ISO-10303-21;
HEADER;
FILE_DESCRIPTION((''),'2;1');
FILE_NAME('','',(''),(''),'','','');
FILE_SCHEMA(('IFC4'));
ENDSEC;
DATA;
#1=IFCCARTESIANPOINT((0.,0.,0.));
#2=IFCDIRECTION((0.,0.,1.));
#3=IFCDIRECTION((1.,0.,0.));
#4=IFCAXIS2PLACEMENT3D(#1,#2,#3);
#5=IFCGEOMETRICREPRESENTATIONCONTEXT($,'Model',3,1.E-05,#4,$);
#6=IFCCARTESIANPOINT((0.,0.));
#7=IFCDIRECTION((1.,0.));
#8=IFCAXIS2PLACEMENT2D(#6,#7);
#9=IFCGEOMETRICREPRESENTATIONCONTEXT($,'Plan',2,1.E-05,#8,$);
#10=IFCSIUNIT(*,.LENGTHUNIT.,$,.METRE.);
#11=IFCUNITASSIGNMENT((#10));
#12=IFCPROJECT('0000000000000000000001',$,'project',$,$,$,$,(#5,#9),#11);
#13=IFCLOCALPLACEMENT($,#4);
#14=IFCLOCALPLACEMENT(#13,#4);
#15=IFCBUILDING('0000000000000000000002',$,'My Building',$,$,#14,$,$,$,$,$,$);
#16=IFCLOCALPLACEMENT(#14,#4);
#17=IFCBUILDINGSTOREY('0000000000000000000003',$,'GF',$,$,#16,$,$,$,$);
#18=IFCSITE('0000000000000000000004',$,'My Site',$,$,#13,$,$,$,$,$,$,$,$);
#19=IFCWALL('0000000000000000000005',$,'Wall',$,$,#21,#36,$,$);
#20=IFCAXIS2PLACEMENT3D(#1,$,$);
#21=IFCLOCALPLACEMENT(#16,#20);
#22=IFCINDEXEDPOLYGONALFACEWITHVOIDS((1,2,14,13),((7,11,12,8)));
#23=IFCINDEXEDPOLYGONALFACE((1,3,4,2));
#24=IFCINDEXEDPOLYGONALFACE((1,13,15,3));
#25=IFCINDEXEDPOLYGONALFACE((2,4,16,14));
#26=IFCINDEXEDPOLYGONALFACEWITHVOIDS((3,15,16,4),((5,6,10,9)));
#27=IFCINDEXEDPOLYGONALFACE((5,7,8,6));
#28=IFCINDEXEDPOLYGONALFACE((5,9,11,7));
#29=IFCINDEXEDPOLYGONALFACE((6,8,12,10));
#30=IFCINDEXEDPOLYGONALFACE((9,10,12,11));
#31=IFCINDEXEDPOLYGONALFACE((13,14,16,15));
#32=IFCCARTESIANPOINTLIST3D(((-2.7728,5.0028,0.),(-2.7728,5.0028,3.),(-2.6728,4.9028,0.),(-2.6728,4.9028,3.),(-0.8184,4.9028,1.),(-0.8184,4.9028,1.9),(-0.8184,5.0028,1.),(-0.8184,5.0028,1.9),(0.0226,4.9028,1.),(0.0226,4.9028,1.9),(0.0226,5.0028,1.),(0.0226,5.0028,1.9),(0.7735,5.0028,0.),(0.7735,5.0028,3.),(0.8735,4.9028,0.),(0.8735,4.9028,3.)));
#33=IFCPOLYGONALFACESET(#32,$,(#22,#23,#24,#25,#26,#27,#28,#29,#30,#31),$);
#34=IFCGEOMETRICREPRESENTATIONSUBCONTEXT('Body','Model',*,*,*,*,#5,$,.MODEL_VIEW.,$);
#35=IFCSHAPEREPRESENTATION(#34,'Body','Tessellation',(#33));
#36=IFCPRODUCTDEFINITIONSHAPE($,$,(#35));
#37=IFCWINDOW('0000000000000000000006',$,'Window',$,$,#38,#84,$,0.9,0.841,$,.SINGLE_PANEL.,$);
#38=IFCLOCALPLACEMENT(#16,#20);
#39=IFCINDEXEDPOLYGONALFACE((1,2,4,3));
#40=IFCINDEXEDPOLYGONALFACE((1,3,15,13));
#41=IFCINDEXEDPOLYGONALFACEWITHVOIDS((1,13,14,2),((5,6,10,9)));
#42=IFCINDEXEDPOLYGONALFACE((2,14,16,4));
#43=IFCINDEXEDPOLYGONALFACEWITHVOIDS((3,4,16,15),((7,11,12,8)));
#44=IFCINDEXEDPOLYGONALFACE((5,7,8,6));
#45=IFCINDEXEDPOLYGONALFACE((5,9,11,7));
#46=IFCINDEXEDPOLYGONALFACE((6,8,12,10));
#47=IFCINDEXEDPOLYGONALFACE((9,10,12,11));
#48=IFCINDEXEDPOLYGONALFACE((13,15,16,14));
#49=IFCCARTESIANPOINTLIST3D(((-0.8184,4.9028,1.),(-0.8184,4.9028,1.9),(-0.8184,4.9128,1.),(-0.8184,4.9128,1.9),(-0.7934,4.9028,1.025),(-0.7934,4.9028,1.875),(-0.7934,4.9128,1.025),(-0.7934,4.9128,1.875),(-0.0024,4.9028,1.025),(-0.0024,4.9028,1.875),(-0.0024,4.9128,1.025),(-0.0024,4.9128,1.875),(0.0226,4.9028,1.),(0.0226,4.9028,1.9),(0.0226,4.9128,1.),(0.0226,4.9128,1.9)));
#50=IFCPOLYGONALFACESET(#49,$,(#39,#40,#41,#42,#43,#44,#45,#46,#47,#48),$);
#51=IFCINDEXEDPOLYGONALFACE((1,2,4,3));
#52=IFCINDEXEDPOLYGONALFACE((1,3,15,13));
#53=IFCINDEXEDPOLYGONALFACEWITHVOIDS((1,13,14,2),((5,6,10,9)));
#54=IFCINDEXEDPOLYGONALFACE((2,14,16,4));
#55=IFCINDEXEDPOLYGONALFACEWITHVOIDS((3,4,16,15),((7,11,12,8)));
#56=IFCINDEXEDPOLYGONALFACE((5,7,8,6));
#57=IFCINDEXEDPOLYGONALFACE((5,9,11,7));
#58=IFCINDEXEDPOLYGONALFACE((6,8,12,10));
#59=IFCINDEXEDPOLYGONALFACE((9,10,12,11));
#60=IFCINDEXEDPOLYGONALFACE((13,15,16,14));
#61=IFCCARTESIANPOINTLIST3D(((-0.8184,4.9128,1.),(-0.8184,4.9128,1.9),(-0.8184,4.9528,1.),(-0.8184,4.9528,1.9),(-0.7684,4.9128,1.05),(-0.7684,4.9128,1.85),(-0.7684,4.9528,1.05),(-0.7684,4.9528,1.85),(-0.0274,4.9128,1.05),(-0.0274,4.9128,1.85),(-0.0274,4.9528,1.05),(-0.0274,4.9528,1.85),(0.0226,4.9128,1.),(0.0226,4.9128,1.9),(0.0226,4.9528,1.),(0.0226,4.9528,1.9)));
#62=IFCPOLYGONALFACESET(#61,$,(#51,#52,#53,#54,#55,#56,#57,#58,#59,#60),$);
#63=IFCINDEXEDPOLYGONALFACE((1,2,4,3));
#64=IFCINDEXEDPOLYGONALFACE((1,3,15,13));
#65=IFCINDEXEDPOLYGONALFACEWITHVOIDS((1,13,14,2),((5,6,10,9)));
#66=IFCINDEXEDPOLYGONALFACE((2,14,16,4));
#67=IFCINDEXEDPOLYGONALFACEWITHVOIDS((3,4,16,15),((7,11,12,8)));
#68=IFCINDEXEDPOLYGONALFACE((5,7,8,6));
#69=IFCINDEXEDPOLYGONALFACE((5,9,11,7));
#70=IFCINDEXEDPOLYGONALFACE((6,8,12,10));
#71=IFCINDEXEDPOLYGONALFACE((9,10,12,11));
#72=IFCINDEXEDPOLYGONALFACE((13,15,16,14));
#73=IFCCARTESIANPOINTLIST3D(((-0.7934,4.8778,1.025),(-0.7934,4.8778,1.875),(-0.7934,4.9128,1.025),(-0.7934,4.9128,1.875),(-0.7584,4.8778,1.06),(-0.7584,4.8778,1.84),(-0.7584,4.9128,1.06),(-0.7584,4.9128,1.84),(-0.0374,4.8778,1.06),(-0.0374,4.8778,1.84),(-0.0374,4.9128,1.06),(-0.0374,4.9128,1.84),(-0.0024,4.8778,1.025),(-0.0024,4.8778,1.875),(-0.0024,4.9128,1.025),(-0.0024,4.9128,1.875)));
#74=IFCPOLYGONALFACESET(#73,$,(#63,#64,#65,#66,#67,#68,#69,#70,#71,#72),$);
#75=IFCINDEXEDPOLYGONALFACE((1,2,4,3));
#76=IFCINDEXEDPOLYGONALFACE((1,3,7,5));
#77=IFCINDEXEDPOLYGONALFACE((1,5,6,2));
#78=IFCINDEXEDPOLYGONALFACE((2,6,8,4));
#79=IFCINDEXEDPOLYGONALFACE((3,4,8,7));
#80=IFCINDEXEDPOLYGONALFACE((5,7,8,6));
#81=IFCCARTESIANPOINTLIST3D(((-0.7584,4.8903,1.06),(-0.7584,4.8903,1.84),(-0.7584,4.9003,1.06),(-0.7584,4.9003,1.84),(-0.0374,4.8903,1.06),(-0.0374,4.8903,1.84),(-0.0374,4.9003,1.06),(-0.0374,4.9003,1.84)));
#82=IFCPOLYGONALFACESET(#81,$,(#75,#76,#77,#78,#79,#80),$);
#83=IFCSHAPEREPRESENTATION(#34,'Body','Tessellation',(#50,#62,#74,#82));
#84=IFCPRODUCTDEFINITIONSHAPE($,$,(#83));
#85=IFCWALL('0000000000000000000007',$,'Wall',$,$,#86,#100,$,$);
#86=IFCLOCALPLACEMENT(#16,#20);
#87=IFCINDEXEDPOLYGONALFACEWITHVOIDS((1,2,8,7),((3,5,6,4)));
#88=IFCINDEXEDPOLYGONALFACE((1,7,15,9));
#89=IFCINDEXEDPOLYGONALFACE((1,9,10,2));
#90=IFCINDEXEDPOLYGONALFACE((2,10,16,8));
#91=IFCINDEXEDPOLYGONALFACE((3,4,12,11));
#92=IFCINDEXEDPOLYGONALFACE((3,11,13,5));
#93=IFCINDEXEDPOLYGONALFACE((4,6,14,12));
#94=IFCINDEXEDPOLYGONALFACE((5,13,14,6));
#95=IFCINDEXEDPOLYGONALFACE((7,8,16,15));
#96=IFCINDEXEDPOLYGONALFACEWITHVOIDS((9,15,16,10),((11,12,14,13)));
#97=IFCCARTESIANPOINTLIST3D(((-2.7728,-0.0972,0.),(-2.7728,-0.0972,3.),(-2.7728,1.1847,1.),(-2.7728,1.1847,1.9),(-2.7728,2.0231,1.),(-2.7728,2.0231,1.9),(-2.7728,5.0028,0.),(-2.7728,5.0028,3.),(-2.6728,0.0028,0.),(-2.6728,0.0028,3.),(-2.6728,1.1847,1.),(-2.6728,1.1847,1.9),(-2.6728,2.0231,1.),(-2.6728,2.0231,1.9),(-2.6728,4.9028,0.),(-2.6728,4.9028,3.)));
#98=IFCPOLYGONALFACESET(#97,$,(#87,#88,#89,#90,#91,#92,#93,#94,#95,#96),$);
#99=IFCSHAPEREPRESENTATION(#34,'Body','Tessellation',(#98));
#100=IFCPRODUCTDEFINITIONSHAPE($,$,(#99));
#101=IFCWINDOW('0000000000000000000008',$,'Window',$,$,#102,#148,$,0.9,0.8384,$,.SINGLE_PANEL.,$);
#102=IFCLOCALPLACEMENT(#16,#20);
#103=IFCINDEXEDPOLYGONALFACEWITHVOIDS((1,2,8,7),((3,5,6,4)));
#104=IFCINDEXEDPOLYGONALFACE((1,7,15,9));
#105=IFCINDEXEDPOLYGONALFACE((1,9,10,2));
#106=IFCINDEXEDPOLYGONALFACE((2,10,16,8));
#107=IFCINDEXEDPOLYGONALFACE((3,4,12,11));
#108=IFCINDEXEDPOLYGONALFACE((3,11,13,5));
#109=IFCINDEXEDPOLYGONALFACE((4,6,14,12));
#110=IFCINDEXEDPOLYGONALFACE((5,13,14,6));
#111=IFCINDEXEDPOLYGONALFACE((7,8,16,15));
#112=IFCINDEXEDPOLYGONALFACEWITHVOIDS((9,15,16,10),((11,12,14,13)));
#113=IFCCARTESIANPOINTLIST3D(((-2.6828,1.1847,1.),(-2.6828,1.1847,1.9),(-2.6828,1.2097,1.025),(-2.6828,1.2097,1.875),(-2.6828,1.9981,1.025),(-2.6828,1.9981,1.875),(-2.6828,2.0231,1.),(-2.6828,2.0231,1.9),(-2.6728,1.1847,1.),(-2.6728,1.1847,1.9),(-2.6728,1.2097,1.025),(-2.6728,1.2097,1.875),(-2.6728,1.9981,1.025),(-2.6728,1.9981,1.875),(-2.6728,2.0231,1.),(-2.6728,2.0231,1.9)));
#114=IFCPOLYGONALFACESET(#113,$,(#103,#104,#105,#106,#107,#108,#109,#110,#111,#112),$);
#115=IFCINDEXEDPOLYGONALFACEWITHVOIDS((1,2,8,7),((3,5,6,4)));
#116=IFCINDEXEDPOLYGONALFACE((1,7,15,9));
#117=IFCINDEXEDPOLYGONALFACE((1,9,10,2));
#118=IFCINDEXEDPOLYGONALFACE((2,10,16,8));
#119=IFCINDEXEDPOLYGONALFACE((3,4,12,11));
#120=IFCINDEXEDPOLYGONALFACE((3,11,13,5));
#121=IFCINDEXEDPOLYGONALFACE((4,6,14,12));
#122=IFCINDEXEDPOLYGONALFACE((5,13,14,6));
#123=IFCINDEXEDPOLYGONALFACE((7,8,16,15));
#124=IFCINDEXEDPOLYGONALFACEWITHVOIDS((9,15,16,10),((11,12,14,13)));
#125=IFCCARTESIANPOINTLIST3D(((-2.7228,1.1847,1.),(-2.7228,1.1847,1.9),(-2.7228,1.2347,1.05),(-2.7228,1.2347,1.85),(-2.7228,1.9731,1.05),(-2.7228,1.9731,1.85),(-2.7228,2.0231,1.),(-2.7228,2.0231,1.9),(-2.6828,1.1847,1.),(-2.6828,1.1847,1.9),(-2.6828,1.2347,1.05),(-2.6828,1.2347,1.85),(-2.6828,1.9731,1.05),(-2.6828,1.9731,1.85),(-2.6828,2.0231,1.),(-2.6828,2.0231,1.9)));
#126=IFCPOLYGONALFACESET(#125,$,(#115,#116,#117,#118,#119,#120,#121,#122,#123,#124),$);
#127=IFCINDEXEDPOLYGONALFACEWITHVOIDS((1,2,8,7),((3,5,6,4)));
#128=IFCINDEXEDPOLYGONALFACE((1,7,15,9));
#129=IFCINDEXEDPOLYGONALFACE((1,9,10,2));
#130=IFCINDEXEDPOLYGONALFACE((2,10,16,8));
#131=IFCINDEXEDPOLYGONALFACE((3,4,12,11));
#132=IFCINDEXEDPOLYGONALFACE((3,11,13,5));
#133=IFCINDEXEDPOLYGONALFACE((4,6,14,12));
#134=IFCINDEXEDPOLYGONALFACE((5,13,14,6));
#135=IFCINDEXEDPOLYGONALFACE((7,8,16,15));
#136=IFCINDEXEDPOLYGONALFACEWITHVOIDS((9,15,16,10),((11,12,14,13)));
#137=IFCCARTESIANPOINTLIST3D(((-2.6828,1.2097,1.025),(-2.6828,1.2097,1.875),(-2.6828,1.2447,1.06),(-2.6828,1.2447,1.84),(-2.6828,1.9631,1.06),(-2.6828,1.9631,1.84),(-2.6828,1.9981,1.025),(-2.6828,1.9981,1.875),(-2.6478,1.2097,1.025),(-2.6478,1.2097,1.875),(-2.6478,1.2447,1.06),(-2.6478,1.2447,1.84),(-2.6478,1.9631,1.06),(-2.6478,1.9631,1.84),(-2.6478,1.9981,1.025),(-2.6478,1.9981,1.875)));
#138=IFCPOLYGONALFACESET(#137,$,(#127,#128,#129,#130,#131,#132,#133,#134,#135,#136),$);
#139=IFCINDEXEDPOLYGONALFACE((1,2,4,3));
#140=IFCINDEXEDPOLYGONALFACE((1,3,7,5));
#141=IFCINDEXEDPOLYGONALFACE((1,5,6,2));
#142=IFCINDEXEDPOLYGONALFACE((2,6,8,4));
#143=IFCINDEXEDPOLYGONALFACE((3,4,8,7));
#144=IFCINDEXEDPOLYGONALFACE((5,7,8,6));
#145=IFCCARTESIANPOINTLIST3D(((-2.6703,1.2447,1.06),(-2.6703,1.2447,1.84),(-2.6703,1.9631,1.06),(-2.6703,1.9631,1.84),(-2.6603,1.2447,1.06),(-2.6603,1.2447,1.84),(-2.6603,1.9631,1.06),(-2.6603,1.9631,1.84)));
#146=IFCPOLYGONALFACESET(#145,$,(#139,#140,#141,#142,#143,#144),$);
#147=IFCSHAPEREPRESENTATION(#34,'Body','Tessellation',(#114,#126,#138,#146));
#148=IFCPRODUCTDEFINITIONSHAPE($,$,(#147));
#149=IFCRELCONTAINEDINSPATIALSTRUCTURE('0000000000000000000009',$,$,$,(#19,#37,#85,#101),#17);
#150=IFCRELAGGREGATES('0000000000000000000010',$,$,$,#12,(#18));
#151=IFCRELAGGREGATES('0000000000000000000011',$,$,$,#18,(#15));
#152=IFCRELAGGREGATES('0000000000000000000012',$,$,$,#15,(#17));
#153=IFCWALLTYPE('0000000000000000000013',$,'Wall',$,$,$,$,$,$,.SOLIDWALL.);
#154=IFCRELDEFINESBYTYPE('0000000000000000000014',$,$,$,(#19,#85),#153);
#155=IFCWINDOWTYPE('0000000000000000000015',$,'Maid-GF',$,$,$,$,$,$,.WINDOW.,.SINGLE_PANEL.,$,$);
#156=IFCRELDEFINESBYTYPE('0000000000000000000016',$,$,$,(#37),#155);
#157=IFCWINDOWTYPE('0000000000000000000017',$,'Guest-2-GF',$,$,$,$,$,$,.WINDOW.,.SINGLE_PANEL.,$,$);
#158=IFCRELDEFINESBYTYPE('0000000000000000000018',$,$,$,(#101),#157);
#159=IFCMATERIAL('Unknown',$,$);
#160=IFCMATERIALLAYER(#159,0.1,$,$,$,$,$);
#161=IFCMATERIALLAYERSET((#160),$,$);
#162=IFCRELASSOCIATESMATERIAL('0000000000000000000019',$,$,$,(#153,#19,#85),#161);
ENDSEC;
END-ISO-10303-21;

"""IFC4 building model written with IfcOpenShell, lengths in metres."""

from ifc_helpers import new_model, entity, si_unit, frame, origin_with_axes, origin_2d_with_axis, place, context, subcontext, project, spatial, line, indexed_curve, outline, extrude, shape, source, transform, mapped, material, layer, layer_set, layer_usage, type_object, type_shapes, element, fill, save


model = new_model("IFC4")

# Units and contexts
model_context = context("Model", 3, precision=1e-05, world=origin_with_axes())
plan_context = context("Plan", 2, precision=1e-05, world=origin_2d_with_axis())
body_context_1 = subcontext(model_context, "Body", "Model", "MODEL_VIEW")
body_context_2 = subcontext(plan_context, "Body", "Plan", "PLAN_VIEW")
ifc_project = project(units=[si_unit("LENGTHUNIT", "METRE")], contexts=[model_context, plan_context])

# Site, building, storey
site_placement = place(None, origin_with_axes())
site = spatial("IfcSite", under=ifc_project, at=site_placement, Name="My Site")
building_placement = place(site_placement, origin_with_axes())
building = spatial("IfcBuilding", under=site, at=building_placement, Name="My Building")
storey_placement = place(building_placement, origin_with_axes())
storey = spatial("IfcBuildingStorey", under=building, at=storey_placement, Name="GF")

# Shared definitions
ifc_material_1 = material(Name="Unknown")

# Shared definitions
ifc_layer_1 = layer(ifc_material_1, 0.1)
ifc_layer_set_1 = layer_set([ifc_layer_1])
wall_type = type_object("IfcWallType", Name="Wall", PredefinedType="SOLIDWALL", material=ifc_layer_set_1)

# Walls, openings, windows
ifc_layer_usage_1 = layer_usage(ifc_layer_set_1, "AXIS2", "POSITIVE", 0.0)
wall_1_placement = place(storey_placement, frame((0.7735, 5.0028, 0.0), z_axis=(0.0, 0.0, 1.0), x_axis=(-1.0, 0.0, 0.0)))
wall_1 = element("IfcWall", 1, at=wall_1_placement, inside=storey, type_object=wall_type, material=ifc_layer_usage_1, Name="Wall", context=body_context_1, shape_type="SweptSolid", body=[
    extrude(outline(indexed_curve([(0.0, 0.0), (-0.1, 0.1), (3.4463, 0.1), (3.5463, 0.0)], segments=[line(1, 2, 3, 4, 1)])), origin_with_axes(), (0.0, 0.0, 1.0), 3.0),
])
shared_shape_1 = source(origin_with_axes(), body_context_1, "Body", "SweptSolid", [
    extrude(outline(indexed_curve([(0.0, 0.0), (0.841, 0.0), (0.841, 0.9), (0.0, 0.9)], segments=[line(1, 2, 3, 4, 1)])), frame((0.0, -0.6, 0.0), z_axis=(0.0, -1.0, 0.0), x_axis=(1.0, 0.0, 0.0)), (0.0, 0.0, -1.0), 1.2),
])
opening_1_placement = place(wall_1_placement, frame((0.7509, 0.0, 1.0), z_axis=(0.0, 0.0, 1.0), x_axis=(1.0, 0.0, 0.0)))
opening_1 = element("IfcOpeningElement", 2, at=opening_1_placement, cuts=wall_1, PredefinedType="OPENING", context=body_context_1, shape_type="MappedRepresentation", body=[
    mapped(shared_shape_1, transform((0.0, 0.0, 0.0), x_axis=(1.0, 0.0, 0.0), y_axis=(0.0, 1.0, 0.0), z_axis=(0.0, 0.0, 1.0), scale=1.0)),
])
window_type_1 = type_object("IfcWindowType", Name="Maid-GF", PartitioningType="SINGLE_PANEL", PredefinedType="WINDOW")
shared_shape_2 = source(origin_with_axes(), body_context_1, "Body", "SweptSolid", [
    extrude(outline(indexed_curve([(0.0, 0.0), (0.841, 0.0), (0.841, 0.9), (0.0, 0.9)], segments=[line(1, 2, 3, 4, 1)]), holes=[indexed_curve([(0.025, 0.025), (0.816, 0.025), (0.816, 0.875), (0.025, 0.875)], segments=[line(1, 2, 3, 4, 1)])]), frame((0.0, 0.09, 0.0), z_axis=(0.0, -1.0, 0.0), x_axis=(1.0, 0.0, 0.0)), (0.0, 0.0, -1.0), 0.01),
    extrude(outline(indexed_curve([(0.0, 0.0), (0.841, 0.0), (0.841, 0.9), (0.0, 0.9)], segments=[line(1, 2, 3, 4, 1)]), holes=[indexed_curve([(0.05, 0.05), (0.791, 0.05), (0.791, 0.85), (0.05, 0.85)], segments=[line(1, 2, 3, 4, 1)])]), frame((0.0, 0.05, 0.0), z_axis=(0.0, -1.0, 0.0), x_axis=(1.0, 0.0, 0.0)), (0.0, 0.0, -1.0), 0.04),
    extrude(outline(indexed_curve([(0.0, 0.0), (0.791, 0.0), (0.791, 0.85), (0.0, 0.85)], segments=[line(1, 2, 3, 4, 1)]), holes=[indexed_curve([(0.035, 0.035), (0.756, 0.035), (0.756, 0.815), (0.035, 0.815)], segments=[line(1, 2, 3, 4, 1)])]), frame((0.025, 0.09, 0.025), z_axis=(0.0, -1.0, 0.0), x_axis=(1.0, 0.0, 0.0)), (0.0, 0.0, -1.0), 0.035),
    extrude(outline(indexed_curve([(0.035, 0.035), (0.756, 0.035), (0.756, 0.815), (0.035, 0.815)], segments=[line(1, 2, 3, 4, 1)])), frame((0.025, 0.1025, 0.025), z_axis=(0.0, -1.0, 0.0), x_axis=(1.0, 0.0, 0.0)), (0.0, 0.0, -1.0), 0.01),
])
shared_shape_3 = source(origin_with_axes(), body_context_2, "Body", "Curve2D", [
    entity("IfcIndexedPolyCurve", entity("IfcCartesianPointList2D", [[0.05, 0.05], [0.791, 0.05]])),
    entity("IfcIndexedPolyCurve", entity("IfcCartesianPointList2D", [[0.0, 0.1], [0.025, 0.1], [0.025, 0.09], [0.05, 0.09], [0.05, 0.05], [0.0, 0.05]]), [entity("IfcLineIndex", [1, 2, 3, 4, 5, 6, 1])]),
    entity("IfcIndexedPolyCurve", entity("IfcCartesianPointList2D", [[0.841, 0.1], [0.816, 0.1], [0.816, 0.09], [0.791, 0.09], [0.791, 0.05], [0.841, 0.05]]), [entity("IfcLineIndex", [1, 2, 3, 4, 5, 6, 1])]),
    entity("IfcIndexedPolyCurve", entity("IfcCartesianPointList2D", [[0.025, 0.09], [0.06, 0.09], [0.06, 0.125], [0.025, 0.125]]), [entity("IfcLineIndex", [1, 2, 3, 4, 1])]),
    entity("IfcIndexedPolyCurve", entity("IfcCartesianPointList2D", [[0.816, 0.09], [0.781, 0.09], [0.781, 0.125], [0.816, 0.125]]), [entity("IfcLineIndex", [1, 2, 3, 4, 1])]),
    entity("IfcIndexedPolyCurve", entity("IfcCartesianPointList2D", [[0.06, 0.09], [0.781, 0.09]])),
    entity("IfcIndexedPolyCurve", entity("IfcCartesianPointList2D", [[0.06, 0.125], [0.781, 0.125]])),
    entity("IfcIndexedPolyCurve", entity("IfcCartesianPointList2D", [[0.06, 0.1075], [0.781, 0.1075]])),
])
type_shapes(window_type_1, [shared_shape_2, shared_shape_3])
window_1_placement = place(opening_1_placement, frame((0.0, 0.0, 0.0), z_axis=(0.0, 0.0, 1.0), x_axis=(1.0, 0.0, 0.0)))
window_1 = element("IfcWindow", 3, at=window_1_placement, inside=storey, type_object=window_type_1, Name="Window", OverallHeight=0.9, OverallWidth=0.841, PartitioningType="SINGLE_PANEL", shapes=[
    shape(body_context_1, "Body", "MappedRepresentation", [mapped(shared_shape_2, transform((0.0, 0.0, 0.0), x_axis=(1.0, 0.0, 0.0), y_axis=(0.0, 1.0, 0.0), z_axis=(0.0, 0.0, 1.0), scale=1.0))]),
    shape(body_context_2, "Body", "MappedRepresentation", [mapped(shared_shape_3, transform((0.0, 0.0, 0.0), x_axis=(1.0, 0.0, 0.0), y_axis=(0.0, 1.0, 0.0), z_axis=(0.0, 0.0, 1.0), scale=1.0))]),
])
fill(opening_1, window_1)
ifc_layer_usage_2 = layer_usage(ifc_layer_set_1, "AXIS2", "POSITIVE", 0.0)
wall_2_placement = place(storey_placement, frame((-2.7728, 5.0028, 0.0), z_axis=(0.0, 0.0, 1.0), x_axis=(0.0, -1.0, 0.0)))
wall_2 = element("IfcWall", 4, at=wall_2_placement, inside=storey, type_object=wall_type, material=ifc_layer_usage_2, Name="Wall", context=body_context_1, shape_type="SweptSolid", body=[
    extrude(outline(indexed_curve([(0.0, 0.0), (0.1, 0.1), (5.0, 0.1), (5.1, 0.0)], segments=[line(1, 2, 3, 4, 1)])), origin_with_axes(), (0.0, 0.0, 1.0), 3.0),
])
shared_shape_4 = source(origin_with_axes(), body_context_1, "Body", "SweptSolid", [
    extrude(outline(indexed_curve([(0.0, 0.0), (0.8384, 0.0), (0.8384, 0.9), (0.0, 0.9)], segments=[line(1, 2, 3, 4, 1)])), frame((0.0, -0.6, 0.0), z_axis=(0.0, -1.0, 0.0), x_axis=(1.0, 0.0, 0.0)), (0.0, 0.0, -1.0), 1.2),
])
opening_2_placement = place(wall_2_placement, frame((2.9797, 0.0, 1.0), z_axis=(0.0, 0.0, 1.0), x_axis=(1.0, 0.0, 0.0)))
opening_2 = element("IfcOpeningElement", 5, at=opening_2_placement, cuts=wall_2, PredefinedType="OPENING", context=body_context_1, shape_type="MappedRepresentation", body=[
    mapped(shared_shape_4, transform((0.0, 0.0, 0.0), x_axis=(1.0, 0.0, 0.0), y_axis=(0.0, 1.0, 0.0), z_axis=(0.0, 0.0, 1.0), scale=1.0)),
])
window_type_2 = type_object("IfcWindowType", Name="Guest-2-GF", PartitioningType="SINGLE_PANEL", PredefinedType="WINDOW")
shared_shape_5 = source(origin_with_axes(), body_context_1, "Body", "SweptSolid", [
    extrude(outline(indexed_curve([(0.0, 0.0), (0.8384, 0.0), (0.8384, 0.9), (0.0, 0.9)], segments=[line(1, 2, 3, 4, 1)]), holes=[indexed_curve([(0.025, 0.025), (0.8134, 0.025), (0.8134, 0.875), (0.025, 0.875)], segments=[line(1, 2, 3, 4, 1)])]), frame((0.0, 0.09, 0.0), z_axis=(0.0, -1.0, 0.0), x_axis=(1.0, 0.0, 0.0)), (0.0, 0.0, -1.0), 0.01),
    extrude(outline(indexed_curve([(0.0, 0.0), (0.8384, 0.0), (0.8384, 0.9), (0.0, 0.9)], segments=[line(1, 2, 3, 4, 1)]), holes=[indexed_curve([(0.05, 0.05), (0.7884, 0.05), (0.7884, 0.85), (0.05, 0.85)], segments=[line(1, 2, 3, 4, 1)])]), frame((0.0, 0.05, 0.0), z_axis=(0.0, -1.0, 0.0), x_axis=(1.0, 0.0, 0.0)), (0.0, 0.0, -1.0), 0.04),
    extrude(outline(indexed_curve([(0.0, 0.0), (0.7884, 0.0), (0.7884, 0.85), (0.0, 0.85)], segments=[line(1, 2, 3, 4, 1)]), holes=[indexed_curve([(0.035, 0.035), (0.7534, 0.035), (0.7534, 0.815), (0.035, 0.815)], segments=[line(1, 2, 3, 4, 1)])]), frame((0.025, 0.09, 0.025), z_axis=(0.0, -1.0, 0.0), x_axis=(1.0, 0.0, 0.0)), (0.0, 0.0, -1.0), 0.035),
    extrude(outline(indexed_curve([(0.035, 0.035), (0.7534, 0.035), (0.7534, 0.815), (0.035, 0.815)], segments=[line(1, 2, 3, 4, 1)])), frame((0.025, 0.1025, 0.025), z_axis=(0.0, -1.0, 0.0), x_axis=(1.0, 0.0, 0.0)), (0.0, 0.0, -1.0), 0.01),
])
shared_shape_6 = source(origin_with_axes(), body_context_2, "Body", "Curve2D", [
    entity("IfcIndexedPolyCurve", entity("IfcCartesianPointList2D", [[0.05, 0.05], [0.7884, 0.05]])),
    entity("IfcIndexedPolyCurve", entity("IfcCartesianPointList2D", [[0.0, 0.1], [0.025, 0.1], [0.025, 0.09], [0.05, 0.09], [0.05, 0.05], [0.0, 0.05]]), [entity("IfcLineIndex", [1, 2, 3, 4, 5, 6, 1])]),
    entity("IfcIndexedPolyCurve", entity("IfcCartesianPointList2D", [[0.8384, 0.1], [0.8134, 0.1], [0.8134, 0.09], [0.7884, 0.09], [0.7884, 0.05], [0.8384, 0.05]]), [entity("IfcLineIndex", [1, 2, 3, 4, 5, 6, 1])]),
    entity("IfcIndexedPolyCurve", entity("IfcCartesianPointList2D", [[0.025, 0.09], [0.06, 0.09], [0.06, 0.125], [0.025, 0.125]]), [entity("IfcLineIndex", [1, 2, 3, 4, 1])]),
    entity("IfcIndexedPolyCurve", entity("IfcCartesianPointList2D", [[0.8134, 0.09], [0.7784, 0.09], [0.7784, 0.125], [0.8134, 0.125]]), [entity("IfcLineIndex", [1, 2, 3, 4, 1])]),
    entity("IfcIndexedPolyCurve", entity("IfcCartesianPointList2D", [[0.06, 0.09], [0.7784, 0.09]])),
    entity("IfcIndexedPolyCurve", entity("IfcCartesianPointList2D", [[0.06, 0.125], [0.7784, 0.125]])),
    entity("IfcIndexedPolyCurve", entity("IfcCartesianPointList2D", [[0.06, 0.1075], [0.7784, 0.1075]])),
])
type_shapes(window_type_2, [shared_shape_5, shared_shape_6])
window_2_placement = place(opening_2_placement, frame((0.0, 0.0, 0.0), z_axis=(0.0, 0.0, 1.0), x_axis=(1.0, 0.0, 0.0)))
window_2 = element("IfcWindow", 6, at=window_2_placement, inside=storey, type_object=window_type_2, Name="Window", OverallHeight=0.9, OverallWidth=0.8384, PartitioningType="SINGLE_PANEL", shapes=[
    shape(body_context_1, "Body", "MappedRepresentation", [mapped(shared_shape_5, transform((0.0, 0.0, 0.0), x_axis=(1.0, 0.0, 0.0), y_axis=(0.0, 1.0, 0.0), z_axis=(0.0, 0.0, 1.0), scale=1.0))]),
    shape(body_context_2, "Body", "MappedRepresentation", [mapped(shared_shape_6, transform((0.0, 0.0, 0.0), x_axis=(1.0, 0.0, 0.0), y_axis=(0.0, 1.0, 0.0), z_axis=(0.0, 0.0, 1.0), scale=1.0))]),
])
fill(opening_2, window_2)

save(model, "model.ifc")
